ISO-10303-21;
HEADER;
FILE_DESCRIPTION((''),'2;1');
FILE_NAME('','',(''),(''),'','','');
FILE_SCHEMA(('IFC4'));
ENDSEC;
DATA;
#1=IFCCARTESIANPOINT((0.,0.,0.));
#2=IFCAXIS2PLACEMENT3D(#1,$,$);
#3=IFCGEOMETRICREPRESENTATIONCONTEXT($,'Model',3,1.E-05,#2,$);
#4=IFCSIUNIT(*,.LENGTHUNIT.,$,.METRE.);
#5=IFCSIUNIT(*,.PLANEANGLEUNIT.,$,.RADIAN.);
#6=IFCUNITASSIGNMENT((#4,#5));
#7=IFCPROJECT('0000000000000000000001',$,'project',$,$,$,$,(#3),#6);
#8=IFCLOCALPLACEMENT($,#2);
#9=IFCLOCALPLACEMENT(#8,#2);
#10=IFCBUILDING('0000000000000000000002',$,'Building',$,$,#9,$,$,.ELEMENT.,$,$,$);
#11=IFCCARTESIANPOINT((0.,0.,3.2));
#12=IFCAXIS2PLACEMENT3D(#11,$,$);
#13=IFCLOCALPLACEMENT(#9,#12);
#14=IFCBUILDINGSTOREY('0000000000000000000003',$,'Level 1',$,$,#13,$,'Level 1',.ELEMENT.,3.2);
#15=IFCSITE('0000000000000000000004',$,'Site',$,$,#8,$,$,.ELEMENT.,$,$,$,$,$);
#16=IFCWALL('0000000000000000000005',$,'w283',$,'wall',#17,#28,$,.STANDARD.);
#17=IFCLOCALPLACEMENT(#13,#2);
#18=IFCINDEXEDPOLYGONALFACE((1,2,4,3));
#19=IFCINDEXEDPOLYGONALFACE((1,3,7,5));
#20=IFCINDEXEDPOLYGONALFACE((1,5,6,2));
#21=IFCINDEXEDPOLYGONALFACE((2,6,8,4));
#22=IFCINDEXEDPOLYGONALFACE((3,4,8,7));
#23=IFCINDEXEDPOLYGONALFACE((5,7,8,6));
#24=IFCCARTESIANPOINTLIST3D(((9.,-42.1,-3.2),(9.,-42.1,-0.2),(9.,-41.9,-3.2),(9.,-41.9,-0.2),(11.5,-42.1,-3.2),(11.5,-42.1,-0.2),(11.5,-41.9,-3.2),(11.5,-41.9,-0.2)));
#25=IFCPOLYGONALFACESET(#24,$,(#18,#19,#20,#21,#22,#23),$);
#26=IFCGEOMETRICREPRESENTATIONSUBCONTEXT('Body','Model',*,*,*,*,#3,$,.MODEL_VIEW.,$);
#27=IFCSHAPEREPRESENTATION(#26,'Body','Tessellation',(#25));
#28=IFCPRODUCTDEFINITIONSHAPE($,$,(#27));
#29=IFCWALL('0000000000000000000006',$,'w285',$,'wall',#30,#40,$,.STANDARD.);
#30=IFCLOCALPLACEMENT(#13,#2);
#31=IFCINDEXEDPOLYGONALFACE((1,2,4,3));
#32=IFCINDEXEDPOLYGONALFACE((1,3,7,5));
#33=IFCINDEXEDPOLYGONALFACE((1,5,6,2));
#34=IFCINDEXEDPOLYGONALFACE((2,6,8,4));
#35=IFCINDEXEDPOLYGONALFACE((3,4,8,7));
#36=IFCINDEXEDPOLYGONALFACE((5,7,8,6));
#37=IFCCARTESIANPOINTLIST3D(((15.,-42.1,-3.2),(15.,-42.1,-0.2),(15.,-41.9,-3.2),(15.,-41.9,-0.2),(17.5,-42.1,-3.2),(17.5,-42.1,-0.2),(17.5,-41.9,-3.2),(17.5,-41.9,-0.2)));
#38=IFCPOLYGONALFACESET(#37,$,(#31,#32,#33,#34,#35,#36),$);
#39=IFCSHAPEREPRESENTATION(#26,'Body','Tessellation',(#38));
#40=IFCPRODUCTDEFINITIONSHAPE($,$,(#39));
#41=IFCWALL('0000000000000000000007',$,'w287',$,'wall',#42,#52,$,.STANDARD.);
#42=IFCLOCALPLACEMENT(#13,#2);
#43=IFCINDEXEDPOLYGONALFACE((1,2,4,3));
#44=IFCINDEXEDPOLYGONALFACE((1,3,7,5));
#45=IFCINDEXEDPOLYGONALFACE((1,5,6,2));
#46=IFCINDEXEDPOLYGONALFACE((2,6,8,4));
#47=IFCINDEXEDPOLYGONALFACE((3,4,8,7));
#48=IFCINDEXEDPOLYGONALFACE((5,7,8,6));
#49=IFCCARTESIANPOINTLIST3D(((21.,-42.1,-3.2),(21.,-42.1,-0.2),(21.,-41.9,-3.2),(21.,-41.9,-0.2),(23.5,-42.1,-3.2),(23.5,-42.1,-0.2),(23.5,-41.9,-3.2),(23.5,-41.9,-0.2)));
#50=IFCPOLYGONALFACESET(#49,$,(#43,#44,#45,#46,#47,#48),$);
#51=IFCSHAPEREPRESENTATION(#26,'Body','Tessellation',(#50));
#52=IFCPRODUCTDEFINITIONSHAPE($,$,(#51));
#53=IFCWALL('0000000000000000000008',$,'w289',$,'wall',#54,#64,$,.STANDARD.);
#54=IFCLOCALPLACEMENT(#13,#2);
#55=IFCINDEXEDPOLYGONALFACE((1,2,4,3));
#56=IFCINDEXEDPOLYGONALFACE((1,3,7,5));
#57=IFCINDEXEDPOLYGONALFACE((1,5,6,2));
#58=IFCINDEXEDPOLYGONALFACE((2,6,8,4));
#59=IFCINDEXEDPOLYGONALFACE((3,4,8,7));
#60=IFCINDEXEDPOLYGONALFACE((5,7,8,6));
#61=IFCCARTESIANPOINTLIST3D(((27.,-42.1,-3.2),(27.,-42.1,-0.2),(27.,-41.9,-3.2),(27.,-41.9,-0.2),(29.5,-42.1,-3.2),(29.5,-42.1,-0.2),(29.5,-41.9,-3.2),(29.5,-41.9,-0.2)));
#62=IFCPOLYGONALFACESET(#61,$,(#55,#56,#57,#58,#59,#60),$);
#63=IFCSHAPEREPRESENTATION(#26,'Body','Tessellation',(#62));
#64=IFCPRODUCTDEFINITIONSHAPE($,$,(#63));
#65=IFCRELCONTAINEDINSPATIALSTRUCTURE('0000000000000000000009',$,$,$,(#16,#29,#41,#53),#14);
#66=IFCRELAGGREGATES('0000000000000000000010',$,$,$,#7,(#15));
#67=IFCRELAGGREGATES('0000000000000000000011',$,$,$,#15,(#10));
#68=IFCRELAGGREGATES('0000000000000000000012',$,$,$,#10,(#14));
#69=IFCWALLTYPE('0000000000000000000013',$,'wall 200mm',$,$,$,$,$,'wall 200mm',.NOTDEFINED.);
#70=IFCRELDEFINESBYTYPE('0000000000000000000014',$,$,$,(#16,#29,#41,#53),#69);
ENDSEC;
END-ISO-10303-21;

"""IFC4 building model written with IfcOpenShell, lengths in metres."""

from ifc_helpers import new_model, si_unit, frame, frame_2d, origin, place, context, subcontext, project, spatial, rectangle, extrude, type_object, element, save


model = new_model("IFC4")

# Units and contexts
model_context = context("Model", 3, precision=1e-05, world=origin())
body_context = subcontext(model_context, "Body", "Model", "MODEL_VIEW")
ifc_project = project(units=[si_unit("LENGTHUNIT", "METRE"), si_unit("PLANEANGLEUNIT", "RADIAN")], contexts=[model_context])

# Site, building, storey
site_placement = place(None, origin())
site = spatial("IfcSite", under=ifc_project, at=site_placement, Name="Site", CompositionType="ELEMENT")
building_placement = place(site_placement, origin())
building = spatial("IfcBuilding", under=site, at=building_placement, Name="Building", CompositionType="ELEMENT")
storey_placement = place(building_placement, frame((0.0, 0.0, 3.2)))
storey = spatial("IfcBuildingStorey", under=building, at=storey_placement, Name="Level 1", LongName="Level 1", CompositionType="ELEMENT", Elevation=3.2)

# Walls
wall_type = type_object("IfcWallType", Name="wall 200mm", ElementType="wall 200mm", PredefinedType="NOTDEFINED")
for number, where, z_axis, x_axis, name in (
    (1, (9.0, -42.0, -3.2), (0.0, 0.0, 1.0), (1.0, 0.0, 0.0), "w283"),
    (2, (15.0, -42.0, -3.2), (0.0, 0.0, 1.0), (1.0, 0.0, 0.0), "w285"),
    (3, (21.0, -42.0, -3.2), (0.0, 0.0, 1.0), (1.0, 0.0, 0.0), "w287"),
    (4, (27.0, -42.0, -3.2), (0.0, 0.0, 1.0), (1.0, 0.0, 0.0), "w289"),
):
    element("IfcWall", number, at=place(storey_placement, frame(where, z_axis=z_axis, x_axis=x_axis)), inside=storey, type_object=wall_type, Name=name, ObjectType="wall", PredefinedType="STANDARD", context=body_context, shape_type="SweptSolid", body=[
        extrude(rectangle(XDim=2.5, YDim=0.2, at=frame_2d((1.25, 0.0))), origin(), (0.0, 0.0, 1.0), 3.0),
    ])

save(model, "model.ifc")
